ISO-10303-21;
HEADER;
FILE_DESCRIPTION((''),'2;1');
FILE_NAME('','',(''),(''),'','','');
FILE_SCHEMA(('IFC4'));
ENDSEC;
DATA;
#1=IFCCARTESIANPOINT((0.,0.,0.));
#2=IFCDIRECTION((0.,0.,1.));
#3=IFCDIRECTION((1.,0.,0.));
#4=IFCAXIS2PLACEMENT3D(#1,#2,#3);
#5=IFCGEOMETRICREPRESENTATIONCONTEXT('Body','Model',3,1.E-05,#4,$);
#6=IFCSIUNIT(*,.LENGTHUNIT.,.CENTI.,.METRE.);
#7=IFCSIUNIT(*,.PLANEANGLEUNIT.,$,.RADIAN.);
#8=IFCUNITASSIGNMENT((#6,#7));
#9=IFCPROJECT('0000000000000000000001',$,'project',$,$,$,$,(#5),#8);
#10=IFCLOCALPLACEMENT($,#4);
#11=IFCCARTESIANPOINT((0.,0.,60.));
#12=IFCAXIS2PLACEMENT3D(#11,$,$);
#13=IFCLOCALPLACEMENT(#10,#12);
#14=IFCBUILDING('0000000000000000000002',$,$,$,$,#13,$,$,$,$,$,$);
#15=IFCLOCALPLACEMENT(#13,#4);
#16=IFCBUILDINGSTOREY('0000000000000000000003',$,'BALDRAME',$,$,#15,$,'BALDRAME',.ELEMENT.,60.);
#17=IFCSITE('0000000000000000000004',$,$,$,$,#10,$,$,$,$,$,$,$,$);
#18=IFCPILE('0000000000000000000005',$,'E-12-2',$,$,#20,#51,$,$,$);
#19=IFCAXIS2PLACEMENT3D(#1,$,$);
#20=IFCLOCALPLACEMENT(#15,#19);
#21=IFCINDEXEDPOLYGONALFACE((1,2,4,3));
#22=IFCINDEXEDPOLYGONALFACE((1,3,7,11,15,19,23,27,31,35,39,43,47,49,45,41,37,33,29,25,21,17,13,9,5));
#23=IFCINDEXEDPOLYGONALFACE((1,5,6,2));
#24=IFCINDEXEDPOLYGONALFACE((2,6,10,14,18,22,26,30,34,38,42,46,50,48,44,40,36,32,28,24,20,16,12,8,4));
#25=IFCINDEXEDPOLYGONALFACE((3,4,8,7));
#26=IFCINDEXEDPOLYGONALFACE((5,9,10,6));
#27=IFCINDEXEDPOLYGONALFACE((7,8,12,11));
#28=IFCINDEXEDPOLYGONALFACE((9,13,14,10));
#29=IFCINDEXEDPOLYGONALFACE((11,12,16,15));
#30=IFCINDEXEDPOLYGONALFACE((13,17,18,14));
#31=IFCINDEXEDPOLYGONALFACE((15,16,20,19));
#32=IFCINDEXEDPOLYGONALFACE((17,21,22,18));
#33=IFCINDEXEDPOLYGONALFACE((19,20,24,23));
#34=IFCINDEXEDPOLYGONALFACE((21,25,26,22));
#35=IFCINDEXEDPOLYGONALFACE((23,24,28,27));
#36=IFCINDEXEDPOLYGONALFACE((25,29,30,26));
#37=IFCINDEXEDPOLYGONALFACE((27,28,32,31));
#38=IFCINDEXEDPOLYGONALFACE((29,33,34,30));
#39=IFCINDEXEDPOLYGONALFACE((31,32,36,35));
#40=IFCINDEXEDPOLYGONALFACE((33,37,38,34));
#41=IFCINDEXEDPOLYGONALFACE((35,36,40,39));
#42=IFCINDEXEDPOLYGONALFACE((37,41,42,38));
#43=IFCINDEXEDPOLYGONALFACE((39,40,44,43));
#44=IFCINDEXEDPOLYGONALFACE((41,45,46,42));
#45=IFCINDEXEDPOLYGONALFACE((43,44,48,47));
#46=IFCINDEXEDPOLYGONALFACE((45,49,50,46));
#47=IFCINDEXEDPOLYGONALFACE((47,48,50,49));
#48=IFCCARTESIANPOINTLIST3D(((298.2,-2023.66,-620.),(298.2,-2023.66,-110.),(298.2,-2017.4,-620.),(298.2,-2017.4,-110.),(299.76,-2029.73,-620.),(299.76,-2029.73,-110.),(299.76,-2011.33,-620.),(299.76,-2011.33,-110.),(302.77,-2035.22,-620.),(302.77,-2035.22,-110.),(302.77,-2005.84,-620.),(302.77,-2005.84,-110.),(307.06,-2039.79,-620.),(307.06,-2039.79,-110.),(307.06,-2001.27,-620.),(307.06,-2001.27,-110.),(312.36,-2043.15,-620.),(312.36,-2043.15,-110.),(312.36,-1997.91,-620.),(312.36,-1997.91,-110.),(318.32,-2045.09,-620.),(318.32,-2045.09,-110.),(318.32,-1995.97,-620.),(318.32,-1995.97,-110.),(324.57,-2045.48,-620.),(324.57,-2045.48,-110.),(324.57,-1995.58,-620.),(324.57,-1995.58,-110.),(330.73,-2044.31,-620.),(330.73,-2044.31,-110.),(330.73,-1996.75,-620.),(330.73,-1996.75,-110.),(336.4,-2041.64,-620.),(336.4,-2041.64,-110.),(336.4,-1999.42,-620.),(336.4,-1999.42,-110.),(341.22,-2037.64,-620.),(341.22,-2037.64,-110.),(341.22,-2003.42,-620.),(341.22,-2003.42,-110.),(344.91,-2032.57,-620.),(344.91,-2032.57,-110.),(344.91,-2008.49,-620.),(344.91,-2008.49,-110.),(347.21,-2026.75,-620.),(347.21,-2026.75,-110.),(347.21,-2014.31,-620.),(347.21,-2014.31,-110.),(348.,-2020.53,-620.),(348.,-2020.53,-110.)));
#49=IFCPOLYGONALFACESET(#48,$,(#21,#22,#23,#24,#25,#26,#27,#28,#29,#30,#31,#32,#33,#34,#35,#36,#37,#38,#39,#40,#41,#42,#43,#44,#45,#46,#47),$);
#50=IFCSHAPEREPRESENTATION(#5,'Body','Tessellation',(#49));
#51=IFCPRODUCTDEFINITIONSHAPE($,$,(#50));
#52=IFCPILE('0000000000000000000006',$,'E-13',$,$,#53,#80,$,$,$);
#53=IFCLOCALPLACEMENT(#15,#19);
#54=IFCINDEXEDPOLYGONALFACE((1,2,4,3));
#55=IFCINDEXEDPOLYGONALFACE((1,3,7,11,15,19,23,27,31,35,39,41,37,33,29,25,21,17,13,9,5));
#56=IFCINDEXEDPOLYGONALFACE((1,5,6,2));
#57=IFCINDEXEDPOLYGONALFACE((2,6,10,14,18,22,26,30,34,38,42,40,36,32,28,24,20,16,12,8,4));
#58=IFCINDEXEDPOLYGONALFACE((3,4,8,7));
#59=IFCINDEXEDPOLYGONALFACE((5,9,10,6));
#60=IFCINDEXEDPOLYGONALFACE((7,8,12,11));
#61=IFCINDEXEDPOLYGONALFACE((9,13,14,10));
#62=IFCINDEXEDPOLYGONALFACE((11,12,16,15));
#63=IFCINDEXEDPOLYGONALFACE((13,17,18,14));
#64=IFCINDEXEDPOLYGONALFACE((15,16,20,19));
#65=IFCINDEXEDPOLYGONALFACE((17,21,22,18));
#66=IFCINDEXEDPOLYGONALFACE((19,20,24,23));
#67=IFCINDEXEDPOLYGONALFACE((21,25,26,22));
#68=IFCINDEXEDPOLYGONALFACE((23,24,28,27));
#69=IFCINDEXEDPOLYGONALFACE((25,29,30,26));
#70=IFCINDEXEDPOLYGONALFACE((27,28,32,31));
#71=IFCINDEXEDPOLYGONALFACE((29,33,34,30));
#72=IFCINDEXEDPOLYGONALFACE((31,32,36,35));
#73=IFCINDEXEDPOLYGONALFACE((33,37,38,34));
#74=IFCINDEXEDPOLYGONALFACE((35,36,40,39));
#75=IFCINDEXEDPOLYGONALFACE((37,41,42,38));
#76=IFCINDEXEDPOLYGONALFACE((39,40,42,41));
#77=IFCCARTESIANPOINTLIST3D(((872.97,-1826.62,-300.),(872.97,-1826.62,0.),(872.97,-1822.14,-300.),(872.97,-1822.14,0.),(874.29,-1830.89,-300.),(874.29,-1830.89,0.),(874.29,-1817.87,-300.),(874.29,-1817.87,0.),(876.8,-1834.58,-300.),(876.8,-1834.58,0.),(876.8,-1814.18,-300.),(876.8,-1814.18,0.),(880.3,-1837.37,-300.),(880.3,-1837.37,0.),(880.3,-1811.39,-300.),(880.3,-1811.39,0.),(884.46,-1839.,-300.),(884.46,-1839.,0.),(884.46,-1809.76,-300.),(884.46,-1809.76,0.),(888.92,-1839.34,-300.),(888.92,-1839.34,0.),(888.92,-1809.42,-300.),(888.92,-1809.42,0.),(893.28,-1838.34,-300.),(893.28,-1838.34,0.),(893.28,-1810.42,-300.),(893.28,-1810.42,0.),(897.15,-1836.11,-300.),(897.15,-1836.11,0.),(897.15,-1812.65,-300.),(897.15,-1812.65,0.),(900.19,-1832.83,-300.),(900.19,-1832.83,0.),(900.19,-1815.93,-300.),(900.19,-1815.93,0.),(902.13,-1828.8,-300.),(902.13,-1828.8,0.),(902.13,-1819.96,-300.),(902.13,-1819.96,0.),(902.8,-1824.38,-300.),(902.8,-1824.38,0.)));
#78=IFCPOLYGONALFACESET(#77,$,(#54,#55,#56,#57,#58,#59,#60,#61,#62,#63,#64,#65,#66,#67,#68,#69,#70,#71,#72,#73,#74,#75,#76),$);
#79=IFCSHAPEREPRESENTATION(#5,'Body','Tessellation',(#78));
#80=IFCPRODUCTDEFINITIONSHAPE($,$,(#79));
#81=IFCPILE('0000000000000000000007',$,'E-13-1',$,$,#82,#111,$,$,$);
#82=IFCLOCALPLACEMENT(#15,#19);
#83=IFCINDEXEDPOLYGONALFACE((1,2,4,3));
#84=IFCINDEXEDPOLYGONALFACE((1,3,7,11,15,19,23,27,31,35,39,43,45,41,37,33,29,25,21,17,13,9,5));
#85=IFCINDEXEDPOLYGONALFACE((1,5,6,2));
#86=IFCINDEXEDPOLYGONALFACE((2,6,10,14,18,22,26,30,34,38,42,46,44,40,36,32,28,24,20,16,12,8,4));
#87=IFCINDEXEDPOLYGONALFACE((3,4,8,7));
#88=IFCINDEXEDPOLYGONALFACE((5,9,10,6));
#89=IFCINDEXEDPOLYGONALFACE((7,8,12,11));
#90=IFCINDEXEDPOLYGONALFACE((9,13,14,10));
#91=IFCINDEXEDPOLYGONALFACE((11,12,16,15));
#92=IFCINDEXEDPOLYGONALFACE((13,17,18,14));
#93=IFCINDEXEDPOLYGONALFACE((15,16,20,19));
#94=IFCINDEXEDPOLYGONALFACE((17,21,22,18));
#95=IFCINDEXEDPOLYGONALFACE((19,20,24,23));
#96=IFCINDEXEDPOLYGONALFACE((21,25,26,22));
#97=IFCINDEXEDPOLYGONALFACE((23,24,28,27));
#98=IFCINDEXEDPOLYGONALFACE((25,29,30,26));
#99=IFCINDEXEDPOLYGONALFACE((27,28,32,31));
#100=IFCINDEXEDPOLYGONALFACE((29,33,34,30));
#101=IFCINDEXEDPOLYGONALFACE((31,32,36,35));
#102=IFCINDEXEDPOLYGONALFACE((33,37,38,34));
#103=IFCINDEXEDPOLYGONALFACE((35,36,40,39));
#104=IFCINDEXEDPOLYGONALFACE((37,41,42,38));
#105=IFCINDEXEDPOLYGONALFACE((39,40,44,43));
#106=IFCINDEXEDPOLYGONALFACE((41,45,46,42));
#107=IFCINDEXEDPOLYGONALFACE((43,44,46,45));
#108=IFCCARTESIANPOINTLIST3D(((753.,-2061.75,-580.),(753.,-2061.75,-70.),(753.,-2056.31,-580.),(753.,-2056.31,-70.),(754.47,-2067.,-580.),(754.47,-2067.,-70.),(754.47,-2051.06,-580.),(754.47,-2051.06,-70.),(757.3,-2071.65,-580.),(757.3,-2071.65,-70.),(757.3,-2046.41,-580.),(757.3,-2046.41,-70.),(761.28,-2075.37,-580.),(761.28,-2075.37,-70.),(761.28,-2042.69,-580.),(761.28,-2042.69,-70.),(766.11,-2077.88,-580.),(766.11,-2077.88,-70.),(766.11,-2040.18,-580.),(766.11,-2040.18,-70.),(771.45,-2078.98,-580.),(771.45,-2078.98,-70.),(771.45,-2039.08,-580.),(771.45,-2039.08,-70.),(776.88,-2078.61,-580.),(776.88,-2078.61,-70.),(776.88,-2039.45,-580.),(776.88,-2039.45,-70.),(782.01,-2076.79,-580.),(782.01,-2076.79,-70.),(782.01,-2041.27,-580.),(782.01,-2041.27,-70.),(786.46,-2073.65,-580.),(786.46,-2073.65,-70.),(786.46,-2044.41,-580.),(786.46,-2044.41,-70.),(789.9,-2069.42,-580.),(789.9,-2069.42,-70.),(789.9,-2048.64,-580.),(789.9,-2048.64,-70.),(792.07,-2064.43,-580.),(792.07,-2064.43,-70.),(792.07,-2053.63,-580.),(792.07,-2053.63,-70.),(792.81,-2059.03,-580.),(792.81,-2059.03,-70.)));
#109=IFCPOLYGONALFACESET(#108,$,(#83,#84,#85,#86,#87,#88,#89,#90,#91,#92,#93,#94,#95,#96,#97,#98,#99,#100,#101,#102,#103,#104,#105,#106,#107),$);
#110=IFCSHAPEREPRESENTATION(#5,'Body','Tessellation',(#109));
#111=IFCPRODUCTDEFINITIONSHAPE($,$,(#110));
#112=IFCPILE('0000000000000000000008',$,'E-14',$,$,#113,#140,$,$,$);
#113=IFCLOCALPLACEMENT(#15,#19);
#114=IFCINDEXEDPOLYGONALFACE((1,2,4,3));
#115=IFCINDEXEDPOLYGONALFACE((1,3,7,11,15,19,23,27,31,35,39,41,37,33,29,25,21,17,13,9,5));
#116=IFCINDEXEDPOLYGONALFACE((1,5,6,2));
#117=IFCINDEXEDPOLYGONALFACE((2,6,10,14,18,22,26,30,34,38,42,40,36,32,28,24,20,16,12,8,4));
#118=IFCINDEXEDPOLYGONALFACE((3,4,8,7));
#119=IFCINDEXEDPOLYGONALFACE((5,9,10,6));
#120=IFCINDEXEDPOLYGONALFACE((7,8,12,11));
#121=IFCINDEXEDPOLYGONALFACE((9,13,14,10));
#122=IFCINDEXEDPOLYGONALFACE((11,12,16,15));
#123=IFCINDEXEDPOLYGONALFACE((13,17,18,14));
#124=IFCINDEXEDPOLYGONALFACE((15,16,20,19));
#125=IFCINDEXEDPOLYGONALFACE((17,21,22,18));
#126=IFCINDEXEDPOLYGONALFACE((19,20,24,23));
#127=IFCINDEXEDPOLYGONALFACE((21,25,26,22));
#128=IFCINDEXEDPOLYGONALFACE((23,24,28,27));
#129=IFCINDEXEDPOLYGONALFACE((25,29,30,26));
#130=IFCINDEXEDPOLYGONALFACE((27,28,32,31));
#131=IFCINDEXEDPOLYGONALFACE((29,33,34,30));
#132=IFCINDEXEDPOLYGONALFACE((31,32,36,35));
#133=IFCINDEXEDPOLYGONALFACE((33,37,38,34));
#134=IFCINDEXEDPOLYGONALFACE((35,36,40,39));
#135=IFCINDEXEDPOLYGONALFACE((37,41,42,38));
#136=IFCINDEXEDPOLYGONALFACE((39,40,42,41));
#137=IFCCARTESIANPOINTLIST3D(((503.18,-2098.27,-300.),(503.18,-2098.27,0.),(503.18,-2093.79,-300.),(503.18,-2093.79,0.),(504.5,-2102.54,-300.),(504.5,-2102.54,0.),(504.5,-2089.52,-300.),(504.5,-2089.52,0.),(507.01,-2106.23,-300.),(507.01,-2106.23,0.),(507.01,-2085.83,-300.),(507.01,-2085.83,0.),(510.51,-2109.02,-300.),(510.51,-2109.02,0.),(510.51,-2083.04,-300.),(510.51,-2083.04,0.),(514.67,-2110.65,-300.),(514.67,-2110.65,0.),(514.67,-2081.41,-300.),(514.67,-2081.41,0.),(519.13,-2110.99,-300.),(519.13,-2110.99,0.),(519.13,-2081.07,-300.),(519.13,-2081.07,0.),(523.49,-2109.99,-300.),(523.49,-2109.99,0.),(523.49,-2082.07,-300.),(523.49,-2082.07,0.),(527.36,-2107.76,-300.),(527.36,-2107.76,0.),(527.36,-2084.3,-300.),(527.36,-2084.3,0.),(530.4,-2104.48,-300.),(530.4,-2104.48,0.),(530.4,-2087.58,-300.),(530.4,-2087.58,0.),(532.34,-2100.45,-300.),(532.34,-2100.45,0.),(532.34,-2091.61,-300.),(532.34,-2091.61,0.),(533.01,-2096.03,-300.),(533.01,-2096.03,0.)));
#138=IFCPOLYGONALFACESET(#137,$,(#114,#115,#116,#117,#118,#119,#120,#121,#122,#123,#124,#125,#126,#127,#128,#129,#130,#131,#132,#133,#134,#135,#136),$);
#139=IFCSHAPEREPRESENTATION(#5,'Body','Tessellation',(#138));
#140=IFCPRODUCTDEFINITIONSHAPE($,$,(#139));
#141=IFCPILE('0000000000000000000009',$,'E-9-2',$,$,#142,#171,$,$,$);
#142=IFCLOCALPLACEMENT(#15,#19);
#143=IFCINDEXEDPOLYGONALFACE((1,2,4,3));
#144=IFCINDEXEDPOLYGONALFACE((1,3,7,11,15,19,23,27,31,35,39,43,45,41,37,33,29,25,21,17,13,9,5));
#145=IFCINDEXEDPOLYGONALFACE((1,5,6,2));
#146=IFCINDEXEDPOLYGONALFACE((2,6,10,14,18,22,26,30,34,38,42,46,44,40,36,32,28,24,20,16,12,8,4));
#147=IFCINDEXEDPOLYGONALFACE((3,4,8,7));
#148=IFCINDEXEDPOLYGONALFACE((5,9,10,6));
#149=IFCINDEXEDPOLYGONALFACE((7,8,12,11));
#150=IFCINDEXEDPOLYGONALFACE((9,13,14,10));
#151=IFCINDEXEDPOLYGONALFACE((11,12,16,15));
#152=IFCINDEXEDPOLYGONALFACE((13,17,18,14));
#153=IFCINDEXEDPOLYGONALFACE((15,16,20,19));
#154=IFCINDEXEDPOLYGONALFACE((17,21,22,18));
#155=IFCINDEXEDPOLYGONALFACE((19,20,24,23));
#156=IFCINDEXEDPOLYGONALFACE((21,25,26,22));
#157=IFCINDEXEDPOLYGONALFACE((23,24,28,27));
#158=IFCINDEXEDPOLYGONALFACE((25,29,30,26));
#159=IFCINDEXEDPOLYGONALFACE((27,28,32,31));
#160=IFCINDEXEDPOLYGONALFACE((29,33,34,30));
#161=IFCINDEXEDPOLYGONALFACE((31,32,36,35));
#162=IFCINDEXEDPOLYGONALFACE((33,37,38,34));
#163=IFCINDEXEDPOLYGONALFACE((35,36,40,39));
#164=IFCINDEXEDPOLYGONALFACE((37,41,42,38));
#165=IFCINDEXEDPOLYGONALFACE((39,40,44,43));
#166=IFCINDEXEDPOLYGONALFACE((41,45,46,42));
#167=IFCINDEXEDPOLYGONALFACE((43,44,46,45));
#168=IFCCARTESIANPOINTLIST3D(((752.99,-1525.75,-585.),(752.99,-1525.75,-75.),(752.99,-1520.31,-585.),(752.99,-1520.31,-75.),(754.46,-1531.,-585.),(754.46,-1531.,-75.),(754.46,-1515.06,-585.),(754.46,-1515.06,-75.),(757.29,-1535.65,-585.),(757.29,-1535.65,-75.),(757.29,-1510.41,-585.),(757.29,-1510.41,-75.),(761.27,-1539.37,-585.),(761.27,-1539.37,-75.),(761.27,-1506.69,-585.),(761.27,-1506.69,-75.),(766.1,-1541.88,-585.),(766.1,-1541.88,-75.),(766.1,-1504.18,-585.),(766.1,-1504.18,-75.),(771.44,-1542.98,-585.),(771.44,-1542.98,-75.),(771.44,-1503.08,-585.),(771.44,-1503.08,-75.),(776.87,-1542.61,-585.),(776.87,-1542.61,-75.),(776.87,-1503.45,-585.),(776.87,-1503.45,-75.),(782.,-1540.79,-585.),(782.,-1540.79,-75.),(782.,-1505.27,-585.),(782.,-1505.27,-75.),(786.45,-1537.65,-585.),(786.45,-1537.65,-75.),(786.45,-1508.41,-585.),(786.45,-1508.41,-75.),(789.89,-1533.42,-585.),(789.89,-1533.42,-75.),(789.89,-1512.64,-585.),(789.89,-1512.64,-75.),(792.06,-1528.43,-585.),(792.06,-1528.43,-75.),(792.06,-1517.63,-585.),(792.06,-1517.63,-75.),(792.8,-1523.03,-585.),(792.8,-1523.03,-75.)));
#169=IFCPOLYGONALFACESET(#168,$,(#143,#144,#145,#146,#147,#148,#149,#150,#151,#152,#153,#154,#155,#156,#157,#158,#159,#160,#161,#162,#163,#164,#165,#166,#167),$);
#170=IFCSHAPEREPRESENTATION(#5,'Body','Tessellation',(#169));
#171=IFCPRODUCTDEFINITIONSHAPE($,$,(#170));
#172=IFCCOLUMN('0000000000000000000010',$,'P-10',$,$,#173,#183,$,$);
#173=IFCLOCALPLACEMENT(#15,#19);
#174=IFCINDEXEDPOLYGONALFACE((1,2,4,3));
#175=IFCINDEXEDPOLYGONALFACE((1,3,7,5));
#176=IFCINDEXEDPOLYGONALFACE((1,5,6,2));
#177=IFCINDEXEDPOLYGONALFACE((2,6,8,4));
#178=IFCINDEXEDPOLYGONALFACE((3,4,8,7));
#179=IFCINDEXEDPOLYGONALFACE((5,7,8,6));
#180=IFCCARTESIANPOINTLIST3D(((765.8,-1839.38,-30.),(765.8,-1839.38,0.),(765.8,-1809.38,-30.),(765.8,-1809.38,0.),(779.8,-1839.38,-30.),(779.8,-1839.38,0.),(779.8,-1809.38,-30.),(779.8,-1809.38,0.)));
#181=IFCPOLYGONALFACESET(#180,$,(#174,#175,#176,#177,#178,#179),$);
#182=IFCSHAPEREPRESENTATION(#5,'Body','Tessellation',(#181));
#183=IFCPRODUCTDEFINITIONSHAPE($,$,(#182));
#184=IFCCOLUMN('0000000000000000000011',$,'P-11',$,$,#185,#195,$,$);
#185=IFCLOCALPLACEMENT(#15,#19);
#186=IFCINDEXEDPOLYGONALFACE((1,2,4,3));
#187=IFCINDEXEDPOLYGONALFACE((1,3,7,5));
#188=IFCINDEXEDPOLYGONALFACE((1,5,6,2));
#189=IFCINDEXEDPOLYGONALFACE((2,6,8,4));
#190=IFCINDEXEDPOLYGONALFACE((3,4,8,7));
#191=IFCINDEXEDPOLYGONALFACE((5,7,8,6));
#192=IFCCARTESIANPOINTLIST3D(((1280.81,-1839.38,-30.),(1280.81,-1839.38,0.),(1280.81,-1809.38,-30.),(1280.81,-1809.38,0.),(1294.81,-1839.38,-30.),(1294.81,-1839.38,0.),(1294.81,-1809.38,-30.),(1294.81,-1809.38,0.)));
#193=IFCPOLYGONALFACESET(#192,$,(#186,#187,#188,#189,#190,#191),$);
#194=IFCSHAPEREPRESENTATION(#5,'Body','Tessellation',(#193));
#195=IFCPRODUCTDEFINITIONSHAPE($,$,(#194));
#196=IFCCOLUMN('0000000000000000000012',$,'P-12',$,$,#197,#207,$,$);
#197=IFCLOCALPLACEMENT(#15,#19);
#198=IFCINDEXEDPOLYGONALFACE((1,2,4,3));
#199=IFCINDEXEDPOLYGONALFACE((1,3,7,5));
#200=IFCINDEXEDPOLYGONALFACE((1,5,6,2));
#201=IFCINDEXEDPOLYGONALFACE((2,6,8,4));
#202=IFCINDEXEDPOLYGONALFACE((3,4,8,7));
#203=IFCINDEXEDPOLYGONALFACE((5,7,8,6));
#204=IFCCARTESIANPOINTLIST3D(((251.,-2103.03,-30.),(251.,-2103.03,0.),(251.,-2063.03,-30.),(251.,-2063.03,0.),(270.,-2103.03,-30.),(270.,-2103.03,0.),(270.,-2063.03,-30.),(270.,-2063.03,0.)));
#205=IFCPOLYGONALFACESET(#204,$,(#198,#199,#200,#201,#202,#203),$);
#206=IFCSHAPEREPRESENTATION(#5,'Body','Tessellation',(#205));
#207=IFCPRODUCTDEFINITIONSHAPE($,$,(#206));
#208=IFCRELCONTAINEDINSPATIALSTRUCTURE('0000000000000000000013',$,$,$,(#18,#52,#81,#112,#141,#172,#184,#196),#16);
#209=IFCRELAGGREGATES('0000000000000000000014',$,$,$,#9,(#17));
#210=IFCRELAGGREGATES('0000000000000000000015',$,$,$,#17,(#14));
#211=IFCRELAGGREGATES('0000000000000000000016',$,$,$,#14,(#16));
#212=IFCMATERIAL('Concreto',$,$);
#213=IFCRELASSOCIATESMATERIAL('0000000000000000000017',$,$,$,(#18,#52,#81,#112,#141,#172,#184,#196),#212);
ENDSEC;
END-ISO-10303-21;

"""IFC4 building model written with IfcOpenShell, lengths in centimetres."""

from ifc_helpers import new_model, si_unit, frame, origin_with_axes, origin_2d_with_axis, place, context, project, spatial, rectangle, circle, extrude, material, element, save


model = new_model("IFC4")

# Units and contexts
model_context = context("Model", 3, precision=1e-05, world=origin_with_axes(), identifier="Body")
ifc_project = project(units=[si_unit("LENGTHUNIT", "METRE", prefix="CENTI"), si_unit("PLANEANGLEUNIT", "RADIAN")], contexts=[model_context])

# Site, building, storey
site_placement = place(None, origin_with_axes())
site = spatial("IfcSite", under=ifc_project, at=site_placement)
building_placement = place(site_placement, frame((0.0, 0.0, 60.0)))
building = spatial("IfcBuilding", under=site, at=building_placement)
storey_placement = place(building_placement, origin_with_axes())
storey = spatial("IfcBuildingStorey", under=building, at=storey_placement, Name="BALDRAME", LongName="BALDRAME", CompositionType="ELEMENT", Elevation=60.0)

# Piles
ifc_material = material(Name="Concreto")
for number, where, z_axis, x_axis, name in (
    (1, (323.0, -2020.53, -110.0), (0.0, 0.0, 1.0), (1.0, 0.0, 0.0), "E-12-2"),
):
    element("IfcPile", number, at=place(storey_placement, frame(where, z_axis=z_axis, x_axis=x_axis)), inside=storey, material=ifc_material, Name=name, context=model_context, shape_type="SweptSolid", body=[
        extrude(circle(Radius=25.0, at=origin_2d_with_axis()), frame((0.0, 0.0, -510.0), z_axis=(0.0, 0.0, 1.0), x_axis=(1.0, 0.0, 0.0)), (0.0, 0.0, 1.0), 510.0),
    ])
pile_1_placement = place(storey_placement, frame((887.8, -1824.38, 0.0), z_axis=(0.0, 0.0, 1.0), x_axis=(1.0, 0.0, 0.0)))
element("IfcPile", 2, at=pile_1_placement, inside=storey, material=ifc_material, Name="E-13", context=model_context, shape_type="SolidModel", body=[
    extrude(circle(Radius=15.0, at=origin_2d_with_axis()), frame((0.0, 0.0, -300.0), z_axis=(0.0, 0.0, 1.0), x_axis=(1.0, 0.0, 0.0)), (0.0, 0.0, 1.0), 300.0),
])
pile_2_placement = place(storey_placement, frame((772.81, -2059.03, -70.0), z_axis=(0.0, 0.0, 1.0), x_axis=(1.0, 0.0, 0.0)))
element("IfcPile", 3, at=pile_2_placement, inside=storey, material=ifc_material, Name="E-13-1", context=model_context, shape_type="SweptSolid", body=[
    extrude(circle(Radius=20.0, at=origin_2d_with_axis()), frame((0.0, 0.0, -510.0), z_axis=(0.0, 0.0, 1.0), x_axis=(1.0, 0.0, 0.0)), (0.0, 0.0, 1.0), 510.0),
])
pile_3_placement = place(storey_placement, frame((518.01, -2096.03, 0.0), z_axis=(0.0, 0.0, 1.0), x_axis=(1.0, 0.0, 0.0)))
element("IfcPile", 4, at=pile_3_placement, inside=storey, material=ifc_material, Name="E-14", context=model_context, shape_type="SolidModel", body=[
    extrude(circle(Radius=15.0, at=origin_2d_with_axis()), frame((0.0, 0.0, -300.0), z_axis=(0.0, 0.0, 1.0), x_axis=(1.0, 0.0, 0.0)), (0.0, 0.0, 1.0), 300.0),
])
pile_4_placement = place(storey_placement, frame((772.8, -1523.03, -75.0), z_axis=(0.0, 0.0, 1.0), x_axis=(1.0, 0.0, 0.0)))
element("IfcPile", 5, at=pile_4_placement, inside=storey, material=ifc_material, Name="E-9-2", context=model_context, shape_type="SweptSolid", body=[
    extrude(circle(Radius=20.0, at=origin_2d_with_axis()), frame((0.0, 0.0, -510.0), z_axis=(0.0, 0.0, 1.0), x_axis=(1.0, 0.0, 0.0)), (0.0, 0.0, 1.0), 510.0),
])

# Columns
for number, where, z_axis, x_axis, name in (
    (6, (772.8, -1824.38, 0.0), (0.0, 0.0, 1.0), (1.0, 0.0, 0.0), "P-10"),
    (7, (1287.81, -1824.38, 0.0), (0.0, 0.0, 1.0), (1.0, 0.0, 0.0), "P-11"),
):
    element("IfcColumn", number, at=place(storey_placement, frame(where, z_axis=z_axis, x_axis=x_axis)), inside=storey, material=ifc_material, Name=name, context=model_context, shape_type="SolidModel", body=[
        extrude(rectangle(XDim=14.0, YDim=30.0, at=origin_2d_with_axis()), frame((0.0, 0.0, -30.0), z_axis=(0.0, 0.0, 1.0), x_axis=(1.0, 0.0, 0.0)), (0.0, 0.0, 1.0), 30.0),
    ])
for number, where, z_axis, x_axis, name in (
    (8, (260.5, -2083.03, 0.0), (0.0, 0.0, 1.0), (1.0, 0.0, 0.0), "P-12"),
):
    element("IfcColumn", number, at=place(storey_placement, frame(where, z_axis=z_axis, x_axis=x_axis)), inside=storey, material=ifc_material, Name=name, context=model_context, shape_type="SolidModel", body=[
        extrude(rectangle(XDim=19.0, YDim=40.0, at=origin_2d_with_axis()), frame((0.0, 0.0, -30.0), z_axis=(0.0, 0.0, 1.0), x_axis=(1.0, 0.0, 0.0)), (0.0, 0.0, 1.0), 30.0),
    ])

save(model, "model.ifc")
